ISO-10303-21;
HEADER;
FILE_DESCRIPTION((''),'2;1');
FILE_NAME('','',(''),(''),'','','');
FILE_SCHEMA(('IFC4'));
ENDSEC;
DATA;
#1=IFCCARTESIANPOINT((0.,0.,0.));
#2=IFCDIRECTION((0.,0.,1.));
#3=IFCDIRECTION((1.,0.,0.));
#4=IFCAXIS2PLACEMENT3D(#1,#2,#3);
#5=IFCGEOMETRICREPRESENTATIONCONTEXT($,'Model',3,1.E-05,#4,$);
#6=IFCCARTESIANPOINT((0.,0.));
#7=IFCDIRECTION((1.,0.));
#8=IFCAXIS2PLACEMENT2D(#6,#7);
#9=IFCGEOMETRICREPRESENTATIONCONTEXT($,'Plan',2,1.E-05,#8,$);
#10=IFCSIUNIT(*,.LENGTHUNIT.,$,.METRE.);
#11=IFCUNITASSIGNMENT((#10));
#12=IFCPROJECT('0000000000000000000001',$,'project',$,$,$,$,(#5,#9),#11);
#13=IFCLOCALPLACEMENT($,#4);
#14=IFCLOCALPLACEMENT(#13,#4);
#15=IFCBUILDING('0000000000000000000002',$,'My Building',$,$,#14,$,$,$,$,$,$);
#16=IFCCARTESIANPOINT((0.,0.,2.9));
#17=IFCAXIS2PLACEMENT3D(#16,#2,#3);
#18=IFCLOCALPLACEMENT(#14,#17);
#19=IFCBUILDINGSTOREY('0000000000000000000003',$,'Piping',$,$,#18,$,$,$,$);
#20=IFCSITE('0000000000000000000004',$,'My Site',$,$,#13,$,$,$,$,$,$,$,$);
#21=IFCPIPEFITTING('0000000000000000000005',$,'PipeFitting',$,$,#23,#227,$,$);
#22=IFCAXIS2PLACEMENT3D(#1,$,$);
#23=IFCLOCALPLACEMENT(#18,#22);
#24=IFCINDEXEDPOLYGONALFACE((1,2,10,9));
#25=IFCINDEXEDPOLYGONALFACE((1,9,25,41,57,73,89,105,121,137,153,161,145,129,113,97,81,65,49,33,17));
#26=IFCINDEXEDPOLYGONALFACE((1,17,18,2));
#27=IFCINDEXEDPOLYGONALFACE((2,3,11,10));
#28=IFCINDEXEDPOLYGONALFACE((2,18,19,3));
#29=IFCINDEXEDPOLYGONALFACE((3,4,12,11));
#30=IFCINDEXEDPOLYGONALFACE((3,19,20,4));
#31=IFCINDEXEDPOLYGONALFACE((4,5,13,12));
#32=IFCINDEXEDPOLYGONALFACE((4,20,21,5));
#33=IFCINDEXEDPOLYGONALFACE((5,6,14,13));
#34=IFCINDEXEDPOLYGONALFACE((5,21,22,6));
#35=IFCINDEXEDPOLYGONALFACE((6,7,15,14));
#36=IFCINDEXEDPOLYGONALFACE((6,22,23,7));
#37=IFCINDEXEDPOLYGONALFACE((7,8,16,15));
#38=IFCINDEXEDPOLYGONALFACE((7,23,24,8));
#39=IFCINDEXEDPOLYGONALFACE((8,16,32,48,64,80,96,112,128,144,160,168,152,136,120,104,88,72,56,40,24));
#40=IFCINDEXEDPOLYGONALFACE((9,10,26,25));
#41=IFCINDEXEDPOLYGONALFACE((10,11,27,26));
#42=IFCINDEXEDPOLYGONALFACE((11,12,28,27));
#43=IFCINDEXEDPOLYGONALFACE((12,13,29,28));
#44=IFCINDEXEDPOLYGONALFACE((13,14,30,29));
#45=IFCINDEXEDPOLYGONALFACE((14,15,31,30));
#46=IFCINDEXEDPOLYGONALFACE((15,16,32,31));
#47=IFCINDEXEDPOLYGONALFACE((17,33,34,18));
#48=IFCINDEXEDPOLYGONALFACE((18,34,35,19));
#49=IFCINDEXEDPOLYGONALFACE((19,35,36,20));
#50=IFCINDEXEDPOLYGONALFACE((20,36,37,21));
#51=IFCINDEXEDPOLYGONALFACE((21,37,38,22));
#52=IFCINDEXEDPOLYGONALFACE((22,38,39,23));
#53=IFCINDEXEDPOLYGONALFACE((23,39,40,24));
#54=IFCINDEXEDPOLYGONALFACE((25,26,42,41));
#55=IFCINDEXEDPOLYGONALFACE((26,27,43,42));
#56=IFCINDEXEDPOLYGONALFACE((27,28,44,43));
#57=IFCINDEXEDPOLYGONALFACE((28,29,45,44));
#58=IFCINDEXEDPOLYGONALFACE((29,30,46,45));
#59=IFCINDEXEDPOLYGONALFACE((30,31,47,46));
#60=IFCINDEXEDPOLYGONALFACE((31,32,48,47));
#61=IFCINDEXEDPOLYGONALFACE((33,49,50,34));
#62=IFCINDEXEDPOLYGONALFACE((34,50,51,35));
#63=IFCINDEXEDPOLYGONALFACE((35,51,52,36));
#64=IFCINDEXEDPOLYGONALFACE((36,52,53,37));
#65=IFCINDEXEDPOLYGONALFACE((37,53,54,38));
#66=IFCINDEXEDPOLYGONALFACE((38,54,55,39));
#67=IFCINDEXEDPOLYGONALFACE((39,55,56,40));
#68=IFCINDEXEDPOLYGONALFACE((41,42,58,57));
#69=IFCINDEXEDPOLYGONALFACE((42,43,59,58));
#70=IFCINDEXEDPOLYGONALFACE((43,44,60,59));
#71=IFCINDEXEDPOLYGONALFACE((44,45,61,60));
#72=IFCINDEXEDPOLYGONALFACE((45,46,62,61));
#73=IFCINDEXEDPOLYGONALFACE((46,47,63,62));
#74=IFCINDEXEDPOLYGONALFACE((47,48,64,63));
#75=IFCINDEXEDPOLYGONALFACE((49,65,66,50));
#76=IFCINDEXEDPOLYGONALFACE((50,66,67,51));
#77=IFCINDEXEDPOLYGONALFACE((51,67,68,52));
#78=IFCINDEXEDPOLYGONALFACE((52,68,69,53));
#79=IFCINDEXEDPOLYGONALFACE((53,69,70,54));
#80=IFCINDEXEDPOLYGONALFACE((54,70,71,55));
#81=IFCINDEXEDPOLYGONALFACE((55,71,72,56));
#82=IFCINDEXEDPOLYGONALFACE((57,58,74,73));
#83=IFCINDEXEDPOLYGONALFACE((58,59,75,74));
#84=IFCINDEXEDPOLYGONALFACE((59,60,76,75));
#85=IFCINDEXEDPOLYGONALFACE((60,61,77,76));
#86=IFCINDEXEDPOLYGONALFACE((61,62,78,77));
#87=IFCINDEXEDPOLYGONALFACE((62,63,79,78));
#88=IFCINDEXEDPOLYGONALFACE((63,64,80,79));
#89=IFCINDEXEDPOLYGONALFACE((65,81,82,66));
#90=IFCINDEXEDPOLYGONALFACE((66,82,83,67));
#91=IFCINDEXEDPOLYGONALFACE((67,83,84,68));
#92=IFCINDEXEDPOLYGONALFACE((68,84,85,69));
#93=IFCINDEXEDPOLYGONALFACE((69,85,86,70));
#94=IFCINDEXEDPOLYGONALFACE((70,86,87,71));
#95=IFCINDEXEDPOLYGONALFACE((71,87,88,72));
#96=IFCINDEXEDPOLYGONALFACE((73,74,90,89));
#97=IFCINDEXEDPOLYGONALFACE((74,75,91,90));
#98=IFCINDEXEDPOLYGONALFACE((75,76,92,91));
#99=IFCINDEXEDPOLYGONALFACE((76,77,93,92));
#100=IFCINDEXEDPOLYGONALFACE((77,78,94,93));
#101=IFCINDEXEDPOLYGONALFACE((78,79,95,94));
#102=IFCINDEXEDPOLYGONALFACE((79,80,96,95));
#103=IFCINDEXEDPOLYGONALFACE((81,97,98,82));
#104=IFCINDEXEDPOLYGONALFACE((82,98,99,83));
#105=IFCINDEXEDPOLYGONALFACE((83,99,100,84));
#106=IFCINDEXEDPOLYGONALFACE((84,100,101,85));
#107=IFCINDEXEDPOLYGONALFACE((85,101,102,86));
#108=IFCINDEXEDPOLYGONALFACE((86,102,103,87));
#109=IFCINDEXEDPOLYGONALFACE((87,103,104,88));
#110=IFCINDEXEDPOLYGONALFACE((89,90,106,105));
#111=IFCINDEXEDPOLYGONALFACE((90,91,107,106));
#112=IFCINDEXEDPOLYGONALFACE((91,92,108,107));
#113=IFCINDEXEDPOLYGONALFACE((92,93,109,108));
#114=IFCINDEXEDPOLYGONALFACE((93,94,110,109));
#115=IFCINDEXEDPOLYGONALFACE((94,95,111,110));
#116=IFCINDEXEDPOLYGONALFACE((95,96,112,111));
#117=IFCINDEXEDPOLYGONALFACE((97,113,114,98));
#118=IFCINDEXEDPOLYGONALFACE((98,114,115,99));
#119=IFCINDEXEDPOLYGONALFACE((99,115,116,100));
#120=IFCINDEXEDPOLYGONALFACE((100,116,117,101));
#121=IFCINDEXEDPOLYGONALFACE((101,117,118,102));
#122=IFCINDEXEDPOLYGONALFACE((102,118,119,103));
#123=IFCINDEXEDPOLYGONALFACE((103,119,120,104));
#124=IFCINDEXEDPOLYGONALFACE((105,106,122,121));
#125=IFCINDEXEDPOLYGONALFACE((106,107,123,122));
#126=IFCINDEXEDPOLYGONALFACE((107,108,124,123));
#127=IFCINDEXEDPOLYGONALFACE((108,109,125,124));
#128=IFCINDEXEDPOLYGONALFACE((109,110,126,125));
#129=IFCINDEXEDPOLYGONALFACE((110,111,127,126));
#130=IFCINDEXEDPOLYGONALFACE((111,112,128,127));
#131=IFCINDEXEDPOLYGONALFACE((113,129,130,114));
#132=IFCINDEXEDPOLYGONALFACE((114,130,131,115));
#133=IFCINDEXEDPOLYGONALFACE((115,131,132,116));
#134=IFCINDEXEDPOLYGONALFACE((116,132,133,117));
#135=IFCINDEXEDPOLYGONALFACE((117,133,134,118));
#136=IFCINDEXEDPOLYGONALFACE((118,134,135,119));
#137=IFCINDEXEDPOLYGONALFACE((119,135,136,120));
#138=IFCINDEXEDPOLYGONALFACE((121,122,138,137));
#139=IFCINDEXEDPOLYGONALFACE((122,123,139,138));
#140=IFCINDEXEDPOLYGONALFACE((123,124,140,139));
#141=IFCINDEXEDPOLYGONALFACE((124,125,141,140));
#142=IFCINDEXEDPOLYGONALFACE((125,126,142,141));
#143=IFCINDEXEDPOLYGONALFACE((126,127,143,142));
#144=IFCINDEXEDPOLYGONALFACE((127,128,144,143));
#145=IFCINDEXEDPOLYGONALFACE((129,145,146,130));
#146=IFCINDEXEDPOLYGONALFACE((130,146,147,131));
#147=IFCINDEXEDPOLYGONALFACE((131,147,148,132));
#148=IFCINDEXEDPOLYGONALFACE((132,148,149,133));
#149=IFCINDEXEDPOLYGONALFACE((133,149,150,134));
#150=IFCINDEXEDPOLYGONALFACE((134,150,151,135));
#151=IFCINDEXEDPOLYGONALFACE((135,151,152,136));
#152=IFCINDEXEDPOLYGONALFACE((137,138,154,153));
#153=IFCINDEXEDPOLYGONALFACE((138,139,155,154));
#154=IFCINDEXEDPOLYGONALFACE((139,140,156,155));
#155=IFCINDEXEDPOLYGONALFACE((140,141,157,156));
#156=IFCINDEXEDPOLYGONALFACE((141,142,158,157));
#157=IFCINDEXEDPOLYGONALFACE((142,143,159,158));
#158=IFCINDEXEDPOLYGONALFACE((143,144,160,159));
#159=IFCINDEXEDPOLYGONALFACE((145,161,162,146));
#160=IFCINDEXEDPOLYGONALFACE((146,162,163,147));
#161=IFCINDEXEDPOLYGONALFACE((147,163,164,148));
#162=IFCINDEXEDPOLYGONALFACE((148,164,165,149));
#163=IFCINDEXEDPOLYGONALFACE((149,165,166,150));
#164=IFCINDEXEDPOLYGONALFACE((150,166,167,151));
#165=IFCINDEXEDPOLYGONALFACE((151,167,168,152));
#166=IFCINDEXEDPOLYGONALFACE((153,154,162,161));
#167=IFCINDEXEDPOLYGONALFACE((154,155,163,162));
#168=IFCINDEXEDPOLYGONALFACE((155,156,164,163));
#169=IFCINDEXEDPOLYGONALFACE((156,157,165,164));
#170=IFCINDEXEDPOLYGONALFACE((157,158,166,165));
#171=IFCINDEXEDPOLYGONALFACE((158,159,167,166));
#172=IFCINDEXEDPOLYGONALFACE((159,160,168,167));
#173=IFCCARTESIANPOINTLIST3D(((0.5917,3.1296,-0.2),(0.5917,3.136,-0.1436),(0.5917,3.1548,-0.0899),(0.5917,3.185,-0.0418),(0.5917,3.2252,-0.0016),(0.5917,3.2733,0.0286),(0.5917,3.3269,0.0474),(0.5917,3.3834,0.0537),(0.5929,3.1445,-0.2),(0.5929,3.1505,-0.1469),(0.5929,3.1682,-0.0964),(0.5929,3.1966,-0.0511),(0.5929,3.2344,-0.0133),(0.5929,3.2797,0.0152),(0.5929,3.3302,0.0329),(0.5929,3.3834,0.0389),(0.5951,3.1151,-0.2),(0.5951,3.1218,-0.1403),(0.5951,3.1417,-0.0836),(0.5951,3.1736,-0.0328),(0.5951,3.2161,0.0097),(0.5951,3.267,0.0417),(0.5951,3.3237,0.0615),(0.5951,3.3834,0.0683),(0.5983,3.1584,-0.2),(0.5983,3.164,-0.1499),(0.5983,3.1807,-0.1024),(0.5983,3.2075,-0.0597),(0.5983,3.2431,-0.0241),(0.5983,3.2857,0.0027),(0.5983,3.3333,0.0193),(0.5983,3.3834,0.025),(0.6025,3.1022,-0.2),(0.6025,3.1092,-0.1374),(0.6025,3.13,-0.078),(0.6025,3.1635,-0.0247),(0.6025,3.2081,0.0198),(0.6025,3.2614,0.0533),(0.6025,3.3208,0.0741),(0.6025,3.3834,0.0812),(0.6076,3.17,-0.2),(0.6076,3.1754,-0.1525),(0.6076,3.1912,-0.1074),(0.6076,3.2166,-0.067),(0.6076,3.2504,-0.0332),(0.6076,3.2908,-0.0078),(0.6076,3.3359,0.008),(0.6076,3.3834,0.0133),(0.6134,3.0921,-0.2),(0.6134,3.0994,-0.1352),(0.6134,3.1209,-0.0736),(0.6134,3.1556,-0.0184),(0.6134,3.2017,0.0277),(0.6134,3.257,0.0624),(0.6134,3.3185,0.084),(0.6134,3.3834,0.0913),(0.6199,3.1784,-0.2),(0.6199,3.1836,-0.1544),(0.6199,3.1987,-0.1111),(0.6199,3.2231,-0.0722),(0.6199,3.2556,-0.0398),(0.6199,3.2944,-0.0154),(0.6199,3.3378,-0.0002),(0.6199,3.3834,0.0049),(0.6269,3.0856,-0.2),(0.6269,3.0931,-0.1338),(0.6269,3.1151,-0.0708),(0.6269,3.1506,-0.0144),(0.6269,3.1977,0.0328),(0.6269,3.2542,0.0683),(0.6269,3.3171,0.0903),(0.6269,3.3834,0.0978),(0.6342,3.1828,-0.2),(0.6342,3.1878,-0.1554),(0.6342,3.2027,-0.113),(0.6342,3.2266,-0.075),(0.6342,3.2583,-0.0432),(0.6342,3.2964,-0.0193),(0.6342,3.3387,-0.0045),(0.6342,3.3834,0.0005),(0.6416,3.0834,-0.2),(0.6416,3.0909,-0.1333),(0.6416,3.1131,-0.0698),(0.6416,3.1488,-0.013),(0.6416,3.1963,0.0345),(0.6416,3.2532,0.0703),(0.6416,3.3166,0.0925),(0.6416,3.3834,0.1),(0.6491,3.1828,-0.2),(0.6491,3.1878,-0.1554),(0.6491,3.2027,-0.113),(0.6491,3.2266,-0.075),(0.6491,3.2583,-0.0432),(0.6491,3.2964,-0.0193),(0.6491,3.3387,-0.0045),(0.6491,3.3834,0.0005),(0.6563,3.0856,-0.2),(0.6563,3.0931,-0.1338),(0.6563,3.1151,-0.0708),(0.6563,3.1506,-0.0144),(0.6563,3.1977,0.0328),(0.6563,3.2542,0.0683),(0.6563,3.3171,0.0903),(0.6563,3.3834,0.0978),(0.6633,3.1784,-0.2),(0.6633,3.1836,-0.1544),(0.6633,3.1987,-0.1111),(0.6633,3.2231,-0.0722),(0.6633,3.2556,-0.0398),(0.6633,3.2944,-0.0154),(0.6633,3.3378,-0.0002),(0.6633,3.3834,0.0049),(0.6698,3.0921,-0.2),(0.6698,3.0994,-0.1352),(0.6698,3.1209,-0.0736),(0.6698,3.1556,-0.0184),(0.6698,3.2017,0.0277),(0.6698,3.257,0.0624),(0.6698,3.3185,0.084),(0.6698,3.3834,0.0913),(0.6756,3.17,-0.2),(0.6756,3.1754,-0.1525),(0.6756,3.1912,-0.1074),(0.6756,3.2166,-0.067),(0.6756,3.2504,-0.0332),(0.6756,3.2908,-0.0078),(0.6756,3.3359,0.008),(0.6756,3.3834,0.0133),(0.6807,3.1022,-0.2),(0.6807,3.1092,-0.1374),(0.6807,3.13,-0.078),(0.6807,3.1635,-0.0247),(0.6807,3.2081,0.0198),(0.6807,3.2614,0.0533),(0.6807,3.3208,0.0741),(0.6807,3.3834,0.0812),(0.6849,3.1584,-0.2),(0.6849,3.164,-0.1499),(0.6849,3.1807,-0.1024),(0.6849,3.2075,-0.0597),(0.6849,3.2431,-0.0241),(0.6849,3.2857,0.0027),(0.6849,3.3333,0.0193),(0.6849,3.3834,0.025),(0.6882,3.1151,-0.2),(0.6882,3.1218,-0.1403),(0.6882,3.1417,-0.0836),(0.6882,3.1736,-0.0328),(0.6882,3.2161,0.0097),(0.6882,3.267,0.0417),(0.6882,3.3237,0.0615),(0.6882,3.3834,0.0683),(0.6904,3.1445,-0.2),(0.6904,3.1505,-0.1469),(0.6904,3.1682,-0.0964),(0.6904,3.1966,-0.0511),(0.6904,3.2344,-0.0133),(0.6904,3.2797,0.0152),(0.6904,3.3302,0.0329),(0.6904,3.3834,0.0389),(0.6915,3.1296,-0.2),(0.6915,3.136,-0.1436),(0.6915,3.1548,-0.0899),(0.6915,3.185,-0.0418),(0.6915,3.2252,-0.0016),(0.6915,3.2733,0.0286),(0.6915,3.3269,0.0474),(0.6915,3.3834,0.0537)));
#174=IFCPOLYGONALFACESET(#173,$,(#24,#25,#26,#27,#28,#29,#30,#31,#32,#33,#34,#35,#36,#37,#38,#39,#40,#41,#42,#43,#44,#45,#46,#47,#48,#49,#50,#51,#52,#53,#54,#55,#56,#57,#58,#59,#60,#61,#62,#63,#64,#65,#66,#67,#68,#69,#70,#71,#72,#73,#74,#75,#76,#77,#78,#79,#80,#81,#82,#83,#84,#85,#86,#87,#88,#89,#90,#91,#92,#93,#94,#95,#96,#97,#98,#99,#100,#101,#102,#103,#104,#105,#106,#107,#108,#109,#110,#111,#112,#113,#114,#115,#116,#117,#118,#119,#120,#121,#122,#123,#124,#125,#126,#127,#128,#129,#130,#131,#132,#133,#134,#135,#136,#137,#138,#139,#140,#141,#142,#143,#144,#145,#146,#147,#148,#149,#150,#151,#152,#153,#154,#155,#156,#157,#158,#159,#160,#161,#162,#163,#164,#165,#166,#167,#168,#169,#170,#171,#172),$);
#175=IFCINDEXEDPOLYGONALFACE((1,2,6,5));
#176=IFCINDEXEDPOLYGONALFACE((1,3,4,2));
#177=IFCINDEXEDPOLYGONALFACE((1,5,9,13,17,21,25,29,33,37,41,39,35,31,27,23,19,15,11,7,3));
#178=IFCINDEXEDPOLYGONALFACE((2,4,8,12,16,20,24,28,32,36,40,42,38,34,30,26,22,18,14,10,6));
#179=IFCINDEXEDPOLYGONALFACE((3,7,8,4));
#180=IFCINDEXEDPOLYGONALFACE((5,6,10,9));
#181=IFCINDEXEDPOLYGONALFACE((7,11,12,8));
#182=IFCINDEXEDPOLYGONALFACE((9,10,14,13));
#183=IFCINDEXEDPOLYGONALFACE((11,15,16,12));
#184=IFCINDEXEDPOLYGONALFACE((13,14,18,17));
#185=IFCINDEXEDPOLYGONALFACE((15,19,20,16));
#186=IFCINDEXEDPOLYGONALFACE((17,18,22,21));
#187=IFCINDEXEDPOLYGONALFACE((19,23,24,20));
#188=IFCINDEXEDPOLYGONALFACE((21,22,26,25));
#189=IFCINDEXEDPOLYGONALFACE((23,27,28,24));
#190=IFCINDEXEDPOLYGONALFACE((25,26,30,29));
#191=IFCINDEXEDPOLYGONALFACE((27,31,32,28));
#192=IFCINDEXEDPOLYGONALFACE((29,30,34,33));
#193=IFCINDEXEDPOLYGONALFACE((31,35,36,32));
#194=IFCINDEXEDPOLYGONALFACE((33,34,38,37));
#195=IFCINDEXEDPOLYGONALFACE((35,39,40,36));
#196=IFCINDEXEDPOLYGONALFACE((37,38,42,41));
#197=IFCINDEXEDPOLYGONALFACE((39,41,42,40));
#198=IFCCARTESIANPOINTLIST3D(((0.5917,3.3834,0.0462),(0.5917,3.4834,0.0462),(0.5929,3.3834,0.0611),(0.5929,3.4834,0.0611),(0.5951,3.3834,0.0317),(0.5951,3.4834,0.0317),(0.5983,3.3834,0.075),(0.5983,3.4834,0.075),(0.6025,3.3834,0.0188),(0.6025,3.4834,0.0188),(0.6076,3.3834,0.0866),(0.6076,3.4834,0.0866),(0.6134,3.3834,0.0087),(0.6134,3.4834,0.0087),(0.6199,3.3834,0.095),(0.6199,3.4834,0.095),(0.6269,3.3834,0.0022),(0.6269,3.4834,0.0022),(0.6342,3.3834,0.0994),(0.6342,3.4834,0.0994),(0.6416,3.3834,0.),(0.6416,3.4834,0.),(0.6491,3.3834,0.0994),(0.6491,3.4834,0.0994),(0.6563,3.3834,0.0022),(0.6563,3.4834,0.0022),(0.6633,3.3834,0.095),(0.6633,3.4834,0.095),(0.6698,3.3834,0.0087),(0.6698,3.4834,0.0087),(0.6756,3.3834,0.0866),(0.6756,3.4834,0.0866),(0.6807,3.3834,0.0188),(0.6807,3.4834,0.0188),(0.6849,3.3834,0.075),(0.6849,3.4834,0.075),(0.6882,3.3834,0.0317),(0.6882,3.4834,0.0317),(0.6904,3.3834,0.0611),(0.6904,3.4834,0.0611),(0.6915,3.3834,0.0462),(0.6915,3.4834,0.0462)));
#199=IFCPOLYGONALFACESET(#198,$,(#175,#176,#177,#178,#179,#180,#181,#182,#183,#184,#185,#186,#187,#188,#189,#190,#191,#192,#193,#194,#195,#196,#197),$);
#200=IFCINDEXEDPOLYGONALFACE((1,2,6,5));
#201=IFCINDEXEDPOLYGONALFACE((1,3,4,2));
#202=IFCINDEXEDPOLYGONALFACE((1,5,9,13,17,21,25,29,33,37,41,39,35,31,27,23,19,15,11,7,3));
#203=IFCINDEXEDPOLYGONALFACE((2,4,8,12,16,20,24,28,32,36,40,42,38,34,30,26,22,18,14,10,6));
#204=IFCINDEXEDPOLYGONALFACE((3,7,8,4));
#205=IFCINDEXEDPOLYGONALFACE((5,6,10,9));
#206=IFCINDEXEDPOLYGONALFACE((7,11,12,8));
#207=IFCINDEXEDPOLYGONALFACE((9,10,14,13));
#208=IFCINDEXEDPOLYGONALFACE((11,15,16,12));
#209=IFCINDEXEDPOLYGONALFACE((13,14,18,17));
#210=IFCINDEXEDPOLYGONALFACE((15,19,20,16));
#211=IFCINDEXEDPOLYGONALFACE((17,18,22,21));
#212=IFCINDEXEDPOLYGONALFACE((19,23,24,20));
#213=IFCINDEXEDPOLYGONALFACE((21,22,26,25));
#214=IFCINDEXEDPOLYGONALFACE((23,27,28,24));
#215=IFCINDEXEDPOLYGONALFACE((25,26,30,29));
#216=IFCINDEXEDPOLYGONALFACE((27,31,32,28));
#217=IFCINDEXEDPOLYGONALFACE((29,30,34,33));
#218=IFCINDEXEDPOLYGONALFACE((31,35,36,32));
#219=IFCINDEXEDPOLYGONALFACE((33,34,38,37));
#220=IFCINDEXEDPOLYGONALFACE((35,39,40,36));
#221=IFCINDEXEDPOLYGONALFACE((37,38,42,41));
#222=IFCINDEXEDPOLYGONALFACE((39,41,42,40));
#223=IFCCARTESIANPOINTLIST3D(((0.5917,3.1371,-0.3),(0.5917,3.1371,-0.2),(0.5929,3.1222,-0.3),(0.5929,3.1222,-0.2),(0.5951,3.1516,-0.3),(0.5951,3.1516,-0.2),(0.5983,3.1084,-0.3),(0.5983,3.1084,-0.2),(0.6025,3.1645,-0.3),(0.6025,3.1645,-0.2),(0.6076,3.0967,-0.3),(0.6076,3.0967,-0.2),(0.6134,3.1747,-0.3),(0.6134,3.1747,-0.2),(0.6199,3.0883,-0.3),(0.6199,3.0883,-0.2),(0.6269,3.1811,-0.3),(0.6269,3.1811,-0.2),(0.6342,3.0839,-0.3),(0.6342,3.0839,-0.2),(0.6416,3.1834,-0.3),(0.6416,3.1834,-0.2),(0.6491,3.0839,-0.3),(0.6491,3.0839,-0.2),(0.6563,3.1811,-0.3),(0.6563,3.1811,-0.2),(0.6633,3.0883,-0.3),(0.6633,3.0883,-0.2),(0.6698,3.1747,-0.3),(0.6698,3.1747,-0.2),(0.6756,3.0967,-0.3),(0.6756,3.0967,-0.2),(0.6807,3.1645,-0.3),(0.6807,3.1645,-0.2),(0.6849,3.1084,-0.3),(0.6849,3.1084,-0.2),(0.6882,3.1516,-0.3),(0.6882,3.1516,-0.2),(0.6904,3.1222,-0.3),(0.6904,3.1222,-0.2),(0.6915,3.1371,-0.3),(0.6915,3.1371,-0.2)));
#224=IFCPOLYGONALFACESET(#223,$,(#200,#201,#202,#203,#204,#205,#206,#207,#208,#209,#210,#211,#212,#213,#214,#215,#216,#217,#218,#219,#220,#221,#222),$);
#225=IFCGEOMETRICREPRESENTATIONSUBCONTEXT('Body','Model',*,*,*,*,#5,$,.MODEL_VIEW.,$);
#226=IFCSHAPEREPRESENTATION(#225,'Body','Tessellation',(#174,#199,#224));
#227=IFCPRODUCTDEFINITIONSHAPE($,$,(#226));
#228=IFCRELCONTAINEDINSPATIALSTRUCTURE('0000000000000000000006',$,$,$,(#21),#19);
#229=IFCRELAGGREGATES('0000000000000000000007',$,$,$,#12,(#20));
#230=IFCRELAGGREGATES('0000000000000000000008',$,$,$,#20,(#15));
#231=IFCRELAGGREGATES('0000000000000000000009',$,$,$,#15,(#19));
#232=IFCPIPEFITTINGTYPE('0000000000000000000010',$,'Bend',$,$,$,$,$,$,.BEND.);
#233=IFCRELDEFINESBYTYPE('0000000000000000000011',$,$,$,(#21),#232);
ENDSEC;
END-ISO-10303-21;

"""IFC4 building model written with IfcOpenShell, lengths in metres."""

from ifc_helpers import new_model, entity, si_unit, frame, origin_with_axes, origin_2d_with_axis, place, context, subcontext, project, spatial, circle, extrude, source, transform, mapped, type_object, type_shapes, element, save


model = new_model("IFC4")

# Units and contexts
model_context = context("Model", 3, precision=1e-05, world=origin_with_axes())
plan_context = context("Plan", 2, precision=1e-05, world=origin_2d_with_axis())
body_context = subcontext(model_context, "Body", "Model", "MODEL_VIEW")
ifc_project = project(units=[si_unit("LENGTHUNIT", "METRE")], contexts=[model_context, plan_context])

# Site, building, storey
site_placement = place(None, origin_with_axes())
site = spatial("IfcSite", under=ifc_project, at=site_placement, Name="My Site")
building_placement = place(site_placement, origin_with_axes())
building = spatial("IfcBuilding", under=site, at=building_placement, Name="My Building")
storey_placement = place(building_placement, frame((0.0, 0.0, 2.9), z_axis=(0.0, 0.0, 1.0), x_axis=(1.0, 0.0, 0.0)))
storey = spatial("IfcBuildingStorey", under=building, at=storey_placement, Name="Piping")

# Pipe fitting
pipe_fitting_type_1 = type_object("IfcPipeFittingType", Name="Bend", PredefinedType="BEND")
shared_shape = source(origin_with_axes(), body_context, "Body", "SolidModel", [
    entity("IfcSweptDiskSolid", entity("IfcIndexedPolyCurve", entity("IfcCartesianPointList3D", [[0.0, 0.0, -0.1], [0.0732, 0.0, -0.2768], [0.25, 0.0, -0.35]]), [entity("IfcArcIndex", [1, 2, 3])]), 0.05),
    extrude(circle(Radius=0.05), origin_with_axes(), (0.0, 0.0, -1.0), 0.1),
    extrude(circle(Radius=0.05), frame((0.25, 0.0, -0.35), z_axis=(1.0, 0.0, 0.0), x_axis=(0.0, 0.0, 1.0)), (0.0, 0.0, 1.0), 0.1),
])
type_shapes(pipe_fitting_type_1, [shared_shape])
for number, where, z_axis, x_axis, name in (
    (1, (0.6416, 3.4834, 0.05), (0.0, 1.0, 0.0), (0.0, 0.0, -1.0), "PipeFitting"),
):
    element("IfcPipeFitting", number, at=place(storey_placement, frame(where, z_axis=z_axis, x_axis=x_axis)), inside=storey, type_object=pipe_fitting_type_1, Name=name, context=body_context, shape_type="MappedRepresentation", body=[
        mapped(shared_shape, transform((0.0, 0.0, 0.0), x_axis=(1.0, 0.0, 0.0), y_axis=(0.0, 1.0, 0.0), z_axis=(0.0, 0.0, 1.0), scale=1.0)),
    ])

save(model, "model.ifc")
